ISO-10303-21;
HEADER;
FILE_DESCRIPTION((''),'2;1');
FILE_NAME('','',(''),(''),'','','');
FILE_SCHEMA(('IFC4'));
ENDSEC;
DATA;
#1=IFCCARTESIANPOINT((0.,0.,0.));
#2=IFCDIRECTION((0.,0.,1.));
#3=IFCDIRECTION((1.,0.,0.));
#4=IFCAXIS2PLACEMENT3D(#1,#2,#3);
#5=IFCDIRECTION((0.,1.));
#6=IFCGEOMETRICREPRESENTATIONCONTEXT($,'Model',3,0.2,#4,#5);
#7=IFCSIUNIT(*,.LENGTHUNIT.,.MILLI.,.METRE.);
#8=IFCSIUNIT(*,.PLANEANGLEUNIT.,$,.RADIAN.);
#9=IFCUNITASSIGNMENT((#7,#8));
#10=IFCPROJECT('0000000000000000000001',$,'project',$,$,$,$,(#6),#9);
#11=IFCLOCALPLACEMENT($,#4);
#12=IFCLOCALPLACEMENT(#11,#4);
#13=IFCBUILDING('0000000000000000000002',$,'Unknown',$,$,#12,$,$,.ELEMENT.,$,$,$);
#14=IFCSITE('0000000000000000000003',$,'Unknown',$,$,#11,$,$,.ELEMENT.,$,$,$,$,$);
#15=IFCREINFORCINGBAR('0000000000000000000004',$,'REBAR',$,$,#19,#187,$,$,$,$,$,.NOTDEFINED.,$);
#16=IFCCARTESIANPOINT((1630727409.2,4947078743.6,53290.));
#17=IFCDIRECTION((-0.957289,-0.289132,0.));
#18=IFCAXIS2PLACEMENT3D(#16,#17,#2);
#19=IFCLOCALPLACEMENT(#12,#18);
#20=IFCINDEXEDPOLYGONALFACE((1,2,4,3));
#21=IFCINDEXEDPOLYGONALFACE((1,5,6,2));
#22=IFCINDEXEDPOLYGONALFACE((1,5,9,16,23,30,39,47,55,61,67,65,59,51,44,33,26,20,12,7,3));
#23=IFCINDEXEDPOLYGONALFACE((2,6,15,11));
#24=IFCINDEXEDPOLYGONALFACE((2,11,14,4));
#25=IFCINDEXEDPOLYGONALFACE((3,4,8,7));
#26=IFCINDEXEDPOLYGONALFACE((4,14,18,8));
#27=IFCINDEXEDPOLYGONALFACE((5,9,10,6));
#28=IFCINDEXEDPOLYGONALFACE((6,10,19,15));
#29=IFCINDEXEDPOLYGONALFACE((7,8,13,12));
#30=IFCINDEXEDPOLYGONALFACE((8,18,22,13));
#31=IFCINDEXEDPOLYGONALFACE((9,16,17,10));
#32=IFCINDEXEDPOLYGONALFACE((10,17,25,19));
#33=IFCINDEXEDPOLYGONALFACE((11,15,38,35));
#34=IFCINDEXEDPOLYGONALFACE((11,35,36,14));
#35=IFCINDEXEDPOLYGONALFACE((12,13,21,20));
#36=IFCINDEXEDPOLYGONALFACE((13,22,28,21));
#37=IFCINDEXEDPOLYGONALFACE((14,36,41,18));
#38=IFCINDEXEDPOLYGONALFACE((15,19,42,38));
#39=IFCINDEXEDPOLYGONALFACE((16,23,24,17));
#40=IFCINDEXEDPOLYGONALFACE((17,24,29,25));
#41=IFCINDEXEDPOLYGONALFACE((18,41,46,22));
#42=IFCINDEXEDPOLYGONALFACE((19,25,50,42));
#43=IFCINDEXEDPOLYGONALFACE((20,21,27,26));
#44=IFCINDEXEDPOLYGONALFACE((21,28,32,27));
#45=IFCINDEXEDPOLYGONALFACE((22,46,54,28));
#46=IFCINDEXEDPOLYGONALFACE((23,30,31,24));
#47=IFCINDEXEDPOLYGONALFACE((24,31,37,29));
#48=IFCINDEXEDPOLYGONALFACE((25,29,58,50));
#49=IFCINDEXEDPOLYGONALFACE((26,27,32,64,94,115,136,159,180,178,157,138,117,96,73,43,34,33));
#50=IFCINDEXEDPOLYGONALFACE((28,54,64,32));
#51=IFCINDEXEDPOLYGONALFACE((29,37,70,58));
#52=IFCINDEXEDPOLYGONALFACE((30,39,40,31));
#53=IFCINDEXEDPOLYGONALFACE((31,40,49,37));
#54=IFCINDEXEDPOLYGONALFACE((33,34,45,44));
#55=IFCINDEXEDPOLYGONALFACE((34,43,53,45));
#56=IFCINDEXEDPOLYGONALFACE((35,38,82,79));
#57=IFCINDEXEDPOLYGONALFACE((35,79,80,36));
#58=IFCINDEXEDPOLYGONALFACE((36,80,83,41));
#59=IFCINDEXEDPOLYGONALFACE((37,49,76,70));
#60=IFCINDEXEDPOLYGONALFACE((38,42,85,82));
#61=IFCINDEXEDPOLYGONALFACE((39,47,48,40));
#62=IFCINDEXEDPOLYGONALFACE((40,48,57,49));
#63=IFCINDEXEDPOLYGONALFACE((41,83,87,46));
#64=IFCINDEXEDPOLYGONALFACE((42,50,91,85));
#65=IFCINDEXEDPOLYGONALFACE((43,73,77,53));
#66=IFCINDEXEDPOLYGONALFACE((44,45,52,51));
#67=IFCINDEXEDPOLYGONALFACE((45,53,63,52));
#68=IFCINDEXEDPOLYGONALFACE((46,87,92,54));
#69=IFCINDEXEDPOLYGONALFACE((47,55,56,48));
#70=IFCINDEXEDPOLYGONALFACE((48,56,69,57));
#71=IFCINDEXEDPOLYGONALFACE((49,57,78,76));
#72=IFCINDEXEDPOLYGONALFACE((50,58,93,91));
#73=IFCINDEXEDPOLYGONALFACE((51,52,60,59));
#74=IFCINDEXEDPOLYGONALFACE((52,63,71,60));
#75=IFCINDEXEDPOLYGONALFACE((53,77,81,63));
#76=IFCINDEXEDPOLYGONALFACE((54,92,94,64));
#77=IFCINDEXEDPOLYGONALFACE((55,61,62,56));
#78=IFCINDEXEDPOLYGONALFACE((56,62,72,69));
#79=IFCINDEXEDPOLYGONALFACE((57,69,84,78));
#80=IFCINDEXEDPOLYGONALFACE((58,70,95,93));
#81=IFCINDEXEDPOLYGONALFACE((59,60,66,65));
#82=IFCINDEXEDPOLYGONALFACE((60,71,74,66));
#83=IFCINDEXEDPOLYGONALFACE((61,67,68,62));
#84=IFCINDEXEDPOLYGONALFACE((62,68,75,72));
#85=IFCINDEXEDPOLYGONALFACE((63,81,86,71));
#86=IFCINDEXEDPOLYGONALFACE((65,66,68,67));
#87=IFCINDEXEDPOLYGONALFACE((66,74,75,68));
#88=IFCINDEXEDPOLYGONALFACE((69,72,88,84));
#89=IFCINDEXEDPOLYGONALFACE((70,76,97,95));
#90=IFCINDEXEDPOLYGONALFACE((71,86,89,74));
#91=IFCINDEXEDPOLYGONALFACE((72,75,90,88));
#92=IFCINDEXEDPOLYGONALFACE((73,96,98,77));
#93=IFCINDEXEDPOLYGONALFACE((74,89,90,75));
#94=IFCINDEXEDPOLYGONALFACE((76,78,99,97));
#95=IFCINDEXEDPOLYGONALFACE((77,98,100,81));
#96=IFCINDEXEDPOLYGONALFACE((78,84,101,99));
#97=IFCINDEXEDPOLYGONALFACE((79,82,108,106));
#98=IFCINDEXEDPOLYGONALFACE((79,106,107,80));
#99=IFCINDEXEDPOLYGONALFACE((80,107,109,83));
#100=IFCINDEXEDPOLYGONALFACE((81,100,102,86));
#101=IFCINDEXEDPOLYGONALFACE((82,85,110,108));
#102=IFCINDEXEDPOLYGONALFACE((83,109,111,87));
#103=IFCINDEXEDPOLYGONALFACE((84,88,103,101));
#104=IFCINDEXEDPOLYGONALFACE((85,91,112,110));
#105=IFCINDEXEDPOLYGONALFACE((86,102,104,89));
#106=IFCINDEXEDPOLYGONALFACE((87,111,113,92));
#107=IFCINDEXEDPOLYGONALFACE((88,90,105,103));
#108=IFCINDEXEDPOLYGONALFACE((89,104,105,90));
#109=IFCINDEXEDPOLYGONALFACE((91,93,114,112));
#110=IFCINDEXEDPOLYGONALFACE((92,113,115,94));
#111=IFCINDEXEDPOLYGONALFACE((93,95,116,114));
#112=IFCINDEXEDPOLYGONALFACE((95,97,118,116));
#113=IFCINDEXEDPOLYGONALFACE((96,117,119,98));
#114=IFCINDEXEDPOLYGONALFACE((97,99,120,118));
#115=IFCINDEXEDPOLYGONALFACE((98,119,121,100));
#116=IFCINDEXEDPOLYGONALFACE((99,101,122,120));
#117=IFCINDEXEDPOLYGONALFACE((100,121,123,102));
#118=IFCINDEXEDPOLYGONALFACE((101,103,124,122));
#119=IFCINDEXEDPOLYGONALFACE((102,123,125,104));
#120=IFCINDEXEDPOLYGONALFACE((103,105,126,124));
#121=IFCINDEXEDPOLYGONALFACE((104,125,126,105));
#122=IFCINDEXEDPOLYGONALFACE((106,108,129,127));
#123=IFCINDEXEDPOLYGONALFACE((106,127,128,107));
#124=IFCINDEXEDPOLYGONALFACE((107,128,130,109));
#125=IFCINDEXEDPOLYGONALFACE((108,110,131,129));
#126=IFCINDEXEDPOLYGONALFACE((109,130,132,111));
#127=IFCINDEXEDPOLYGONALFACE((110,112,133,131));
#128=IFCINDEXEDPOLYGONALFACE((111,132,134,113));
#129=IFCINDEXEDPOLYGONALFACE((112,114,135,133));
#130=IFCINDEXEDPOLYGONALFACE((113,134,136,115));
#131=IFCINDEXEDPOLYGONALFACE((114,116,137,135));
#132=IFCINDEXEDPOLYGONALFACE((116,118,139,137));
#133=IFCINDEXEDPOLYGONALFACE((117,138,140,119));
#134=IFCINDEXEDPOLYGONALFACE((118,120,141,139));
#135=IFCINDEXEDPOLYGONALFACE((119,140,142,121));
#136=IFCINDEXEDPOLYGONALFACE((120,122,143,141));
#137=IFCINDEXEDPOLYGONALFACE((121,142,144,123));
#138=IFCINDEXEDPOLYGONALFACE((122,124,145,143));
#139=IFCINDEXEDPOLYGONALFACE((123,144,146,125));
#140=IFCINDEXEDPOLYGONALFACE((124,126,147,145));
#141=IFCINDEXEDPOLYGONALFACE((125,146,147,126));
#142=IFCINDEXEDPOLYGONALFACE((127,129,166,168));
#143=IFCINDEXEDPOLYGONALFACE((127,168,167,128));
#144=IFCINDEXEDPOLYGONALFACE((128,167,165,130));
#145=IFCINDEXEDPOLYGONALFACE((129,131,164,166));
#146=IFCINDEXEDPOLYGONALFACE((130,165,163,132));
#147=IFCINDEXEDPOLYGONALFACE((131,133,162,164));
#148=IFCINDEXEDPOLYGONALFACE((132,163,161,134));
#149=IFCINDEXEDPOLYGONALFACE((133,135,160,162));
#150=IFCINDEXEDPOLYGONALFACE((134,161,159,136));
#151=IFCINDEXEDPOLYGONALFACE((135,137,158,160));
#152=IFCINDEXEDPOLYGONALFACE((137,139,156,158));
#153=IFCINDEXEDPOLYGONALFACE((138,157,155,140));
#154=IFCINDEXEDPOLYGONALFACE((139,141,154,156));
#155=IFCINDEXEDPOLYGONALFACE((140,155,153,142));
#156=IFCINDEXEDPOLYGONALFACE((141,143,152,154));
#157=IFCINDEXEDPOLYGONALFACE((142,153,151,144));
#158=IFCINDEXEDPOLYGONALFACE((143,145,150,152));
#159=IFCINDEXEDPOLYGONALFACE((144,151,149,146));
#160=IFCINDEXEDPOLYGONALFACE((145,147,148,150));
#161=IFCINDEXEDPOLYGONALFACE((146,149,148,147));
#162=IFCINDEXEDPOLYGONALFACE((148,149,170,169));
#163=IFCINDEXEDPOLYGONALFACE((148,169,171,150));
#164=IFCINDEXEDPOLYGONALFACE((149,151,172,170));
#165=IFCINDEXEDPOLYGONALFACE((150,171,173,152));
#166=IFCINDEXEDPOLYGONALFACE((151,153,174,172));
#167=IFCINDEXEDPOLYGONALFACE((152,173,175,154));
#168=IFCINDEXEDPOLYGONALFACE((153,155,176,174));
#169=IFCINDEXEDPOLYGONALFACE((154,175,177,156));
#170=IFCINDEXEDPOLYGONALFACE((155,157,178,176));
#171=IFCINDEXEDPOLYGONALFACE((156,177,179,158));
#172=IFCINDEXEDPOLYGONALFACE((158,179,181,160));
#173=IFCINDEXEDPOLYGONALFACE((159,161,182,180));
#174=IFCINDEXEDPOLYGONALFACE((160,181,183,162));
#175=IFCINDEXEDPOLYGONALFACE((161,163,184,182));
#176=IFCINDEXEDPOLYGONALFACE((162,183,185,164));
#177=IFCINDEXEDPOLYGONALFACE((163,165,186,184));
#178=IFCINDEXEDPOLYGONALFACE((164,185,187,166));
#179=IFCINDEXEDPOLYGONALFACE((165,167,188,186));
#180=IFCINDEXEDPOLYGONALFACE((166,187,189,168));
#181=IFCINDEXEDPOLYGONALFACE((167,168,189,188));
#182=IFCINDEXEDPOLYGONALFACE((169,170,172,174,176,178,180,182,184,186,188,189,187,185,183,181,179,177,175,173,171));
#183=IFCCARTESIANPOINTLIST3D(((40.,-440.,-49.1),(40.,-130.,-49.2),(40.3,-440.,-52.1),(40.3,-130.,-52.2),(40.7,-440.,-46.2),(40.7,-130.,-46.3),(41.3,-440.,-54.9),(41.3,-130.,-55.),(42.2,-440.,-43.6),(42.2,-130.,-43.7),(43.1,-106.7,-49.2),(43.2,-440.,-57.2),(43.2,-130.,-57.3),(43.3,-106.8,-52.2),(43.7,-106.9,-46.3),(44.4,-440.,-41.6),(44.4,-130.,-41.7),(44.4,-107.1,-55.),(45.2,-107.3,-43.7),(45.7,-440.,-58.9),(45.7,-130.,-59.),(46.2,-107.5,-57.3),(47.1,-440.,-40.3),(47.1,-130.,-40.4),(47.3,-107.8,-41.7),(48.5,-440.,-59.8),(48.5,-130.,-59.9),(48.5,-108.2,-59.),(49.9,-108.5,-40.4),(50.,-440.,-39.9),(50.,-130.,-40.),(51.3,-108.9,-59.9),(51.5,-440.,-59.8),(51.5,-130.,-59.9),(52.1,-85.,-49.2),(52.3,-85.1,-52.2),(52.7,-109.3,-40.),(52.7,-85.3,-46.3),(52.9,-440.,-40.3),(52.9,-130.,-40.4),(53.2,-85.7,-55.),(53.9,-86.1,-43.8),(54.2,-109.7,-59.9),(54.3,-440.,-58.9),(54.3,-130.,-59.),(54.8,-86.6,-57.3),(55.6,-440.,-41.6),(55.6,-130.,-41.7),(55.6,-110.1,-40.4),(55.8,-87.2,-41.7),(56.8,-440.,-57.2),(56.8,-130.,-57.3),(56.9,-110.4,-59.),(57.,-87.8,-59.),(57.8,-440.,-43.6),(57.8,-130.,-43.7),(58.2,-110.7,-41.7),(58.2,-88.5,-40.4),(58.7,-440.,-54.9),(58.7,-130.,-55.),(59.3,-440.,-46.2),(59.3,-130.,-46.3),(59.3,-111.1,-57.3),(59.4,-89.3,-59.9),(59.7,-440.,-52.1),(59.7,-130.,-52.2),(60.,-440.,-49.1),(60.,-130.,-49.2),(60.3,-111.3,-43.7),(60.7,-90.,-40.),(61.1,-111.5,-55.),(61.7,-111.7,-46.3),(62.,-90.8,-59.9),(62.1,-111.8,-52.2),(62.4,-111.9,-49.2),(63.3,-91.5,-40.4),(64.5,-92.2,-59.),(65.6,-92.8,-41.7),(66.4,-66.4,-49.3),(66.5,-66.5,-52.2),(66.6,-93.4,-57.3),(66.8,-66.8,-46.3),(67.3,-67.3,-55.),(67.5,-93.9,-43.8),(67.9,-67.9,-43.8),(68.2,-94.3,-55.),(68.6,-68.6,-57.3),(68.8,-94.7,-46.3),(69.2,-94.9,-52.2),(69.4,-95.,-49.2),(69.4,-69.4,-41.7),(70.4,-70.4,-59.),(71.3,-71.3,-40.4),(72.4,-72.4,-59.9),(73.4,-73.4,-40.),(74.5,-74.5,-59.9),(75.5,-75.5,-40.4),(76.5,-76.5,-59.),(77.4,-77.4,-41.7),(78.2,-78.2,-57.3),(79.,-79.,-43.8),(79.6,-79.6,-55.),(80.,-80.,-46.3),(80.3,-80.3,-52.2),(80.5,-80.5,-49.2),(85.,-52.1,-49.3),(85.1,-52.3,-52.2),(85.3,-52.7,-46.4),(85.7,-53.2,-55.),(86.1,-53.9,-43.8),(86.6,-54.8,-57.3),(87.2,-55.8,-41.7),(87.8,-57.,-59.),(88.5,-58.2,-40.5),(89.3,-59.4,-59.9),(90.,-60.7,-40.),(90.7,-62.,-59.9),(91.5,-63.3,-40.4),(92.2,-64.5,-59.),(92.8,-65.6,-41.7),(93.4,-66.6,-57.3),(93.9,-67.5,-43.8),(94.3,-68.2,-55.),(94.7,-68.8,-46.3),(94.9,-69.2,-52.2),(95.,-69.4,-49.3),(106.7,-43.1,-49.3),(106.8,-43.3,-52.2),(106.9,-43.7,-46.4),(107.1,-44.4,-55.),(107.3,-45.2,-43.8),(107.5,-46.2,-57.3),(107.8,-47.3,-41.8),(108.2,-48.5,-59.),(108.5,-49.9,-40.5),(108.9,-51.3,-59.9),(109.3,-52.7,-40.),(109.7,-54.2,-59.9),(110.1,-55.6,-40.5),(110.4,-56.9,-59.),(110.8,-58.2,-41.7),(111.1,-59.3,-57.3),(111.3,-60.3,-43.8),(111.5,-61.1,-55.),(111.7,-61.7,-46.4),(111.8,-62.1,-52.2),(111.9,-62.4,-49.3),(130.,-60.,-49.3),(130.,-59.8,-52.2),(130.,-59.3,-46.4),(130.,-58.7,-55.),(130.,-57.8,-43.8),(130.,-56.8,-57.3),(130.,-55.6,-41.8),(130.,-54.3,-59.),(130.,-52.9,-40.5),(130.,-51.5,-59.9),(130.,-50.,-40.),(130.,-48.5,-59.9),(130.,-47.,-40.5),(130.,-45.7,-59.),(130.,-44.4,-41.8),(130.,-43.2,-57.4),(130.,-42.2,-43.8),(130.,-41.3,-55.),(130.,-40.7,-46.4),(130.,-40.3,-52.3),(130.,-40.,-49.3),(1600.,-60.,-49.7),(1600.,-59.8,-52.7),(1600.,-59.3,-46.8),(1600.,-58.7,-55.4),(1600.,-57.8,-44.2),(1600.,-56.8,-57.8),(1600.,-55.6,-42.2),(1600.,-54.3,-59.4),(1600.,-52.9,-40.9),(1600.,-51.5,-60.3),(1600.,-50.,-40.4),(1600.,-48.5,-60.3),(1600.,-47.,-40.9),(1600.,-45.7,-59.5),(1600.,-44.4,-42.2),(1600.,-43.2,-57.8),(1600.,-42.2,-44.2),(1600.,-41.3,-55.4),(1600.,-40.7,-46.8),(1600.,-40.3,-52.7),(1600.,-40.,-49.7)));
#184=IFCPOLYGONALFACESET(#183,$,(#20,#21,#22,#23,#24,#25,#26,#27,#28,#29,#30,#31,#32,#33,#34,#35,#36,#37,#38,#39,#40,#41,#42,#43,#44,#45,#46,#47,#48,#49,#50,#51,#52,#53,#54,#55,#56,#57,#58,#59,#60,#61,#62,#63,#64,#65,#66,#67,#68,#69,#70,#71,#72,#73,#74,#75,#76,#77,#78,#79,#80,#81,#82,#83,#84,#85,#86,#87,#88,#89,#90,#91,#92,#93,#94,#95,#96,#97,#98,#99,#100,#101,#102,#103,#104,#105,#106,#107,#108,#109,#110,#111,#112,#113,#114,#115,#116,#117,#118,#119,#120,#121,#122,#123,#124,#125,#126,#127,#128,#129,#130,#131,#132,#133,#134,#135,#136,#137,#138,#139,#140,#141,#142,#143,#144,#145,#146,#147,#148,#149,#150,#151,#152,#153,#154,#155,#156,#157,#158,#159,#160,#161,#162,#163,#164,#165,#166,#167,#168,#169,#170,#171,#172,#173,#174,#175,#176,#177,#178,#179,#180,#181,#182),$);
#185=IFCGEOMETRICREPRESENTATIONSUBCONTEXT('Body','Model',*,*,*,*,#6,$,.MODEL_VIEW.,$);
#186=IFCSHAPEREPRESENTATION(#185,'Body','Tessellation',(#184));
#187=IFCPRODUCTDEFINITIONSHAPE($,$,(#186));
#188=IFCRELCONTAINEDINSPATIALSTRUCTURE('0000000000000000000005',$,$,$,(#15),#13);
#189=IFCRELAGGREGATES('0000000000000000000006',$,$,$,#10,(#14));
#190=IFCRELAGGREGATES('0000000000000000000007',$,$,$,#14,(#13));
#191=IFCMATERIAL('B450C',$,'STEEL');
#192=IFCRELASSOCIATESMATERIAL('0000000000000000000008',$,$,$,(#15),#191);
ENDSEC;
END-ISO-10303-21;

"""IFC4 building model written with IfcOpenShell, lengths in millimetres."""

from ifc_helpers import new_model, entity, si_unit, direction, frame, origin_with_axes, place, context, subcontext, project, spatial, material, element, save


model = new_model("IFC4")

# Units and contexts
model_context = context("Model", 3, precision=0.2, world=origin_with_axes(), true_north=direction((0.0, 1.0)))
body_context = subcontext(model_context, "Body", "Model", "MODEL_VIEW")
ifc_project = project(units=[si_unit("LENGTHUNIT", "METRE", prefix="MILLI"), si_unit("PLANEANGLEUNIT", "RADIAN")], contexts=[model_context])

# Site, building
site_placement = place(None, origin_with_axes())
site = spatial("IfcSite", under=ifc_project, at=site_placement, Name="Unknown", CompositionType="ELEMENT")
building_placement = place(site_placement, origin_with_axes())
building = spatial("IfcBuilding", under=site, at=building_placement, Name="Unknown", CompositionType="ELEMENT")

# Reinforcing bar
ifc_material = material(Name="B450C", Category="STEEL")
reinforcing_bar_1_placement = place(building_placement, frame((1630727409.2, 4947078743.6, 53290.0), z_axis=(-0.957289, -0.289132, 0.0), x_axis=(0.0, 0.0, 1.0)))
element("IfcReinforcingBar", 1, at=reinforcing_bar_1_placement, inside=building, material=ifc_material, Name="REBAR", PredefinedType="NOTDEFINED", context=body_context, shape_type="AdvancedSweptSolid", body=[
    entity("IfcSweptDiskSolid", entity("IfcIndexedPolyCurve", entity("IfcCartesianPointList3D", [[50.0, -440.0, -49.9], [50.0, -130.0, -50.0], [73.4, -73.4, -50.0], [130.0, -50.0, -50.0], [1600.0, -50.0, -50.4]]), [entity("IfcLineIndex", [1, 2]), entity("IfcArcIndex", [2, 3, 4]), entity("IfcLineIndex", [4, 5])]), 10.0),
])

save(model, "model.ifc")
